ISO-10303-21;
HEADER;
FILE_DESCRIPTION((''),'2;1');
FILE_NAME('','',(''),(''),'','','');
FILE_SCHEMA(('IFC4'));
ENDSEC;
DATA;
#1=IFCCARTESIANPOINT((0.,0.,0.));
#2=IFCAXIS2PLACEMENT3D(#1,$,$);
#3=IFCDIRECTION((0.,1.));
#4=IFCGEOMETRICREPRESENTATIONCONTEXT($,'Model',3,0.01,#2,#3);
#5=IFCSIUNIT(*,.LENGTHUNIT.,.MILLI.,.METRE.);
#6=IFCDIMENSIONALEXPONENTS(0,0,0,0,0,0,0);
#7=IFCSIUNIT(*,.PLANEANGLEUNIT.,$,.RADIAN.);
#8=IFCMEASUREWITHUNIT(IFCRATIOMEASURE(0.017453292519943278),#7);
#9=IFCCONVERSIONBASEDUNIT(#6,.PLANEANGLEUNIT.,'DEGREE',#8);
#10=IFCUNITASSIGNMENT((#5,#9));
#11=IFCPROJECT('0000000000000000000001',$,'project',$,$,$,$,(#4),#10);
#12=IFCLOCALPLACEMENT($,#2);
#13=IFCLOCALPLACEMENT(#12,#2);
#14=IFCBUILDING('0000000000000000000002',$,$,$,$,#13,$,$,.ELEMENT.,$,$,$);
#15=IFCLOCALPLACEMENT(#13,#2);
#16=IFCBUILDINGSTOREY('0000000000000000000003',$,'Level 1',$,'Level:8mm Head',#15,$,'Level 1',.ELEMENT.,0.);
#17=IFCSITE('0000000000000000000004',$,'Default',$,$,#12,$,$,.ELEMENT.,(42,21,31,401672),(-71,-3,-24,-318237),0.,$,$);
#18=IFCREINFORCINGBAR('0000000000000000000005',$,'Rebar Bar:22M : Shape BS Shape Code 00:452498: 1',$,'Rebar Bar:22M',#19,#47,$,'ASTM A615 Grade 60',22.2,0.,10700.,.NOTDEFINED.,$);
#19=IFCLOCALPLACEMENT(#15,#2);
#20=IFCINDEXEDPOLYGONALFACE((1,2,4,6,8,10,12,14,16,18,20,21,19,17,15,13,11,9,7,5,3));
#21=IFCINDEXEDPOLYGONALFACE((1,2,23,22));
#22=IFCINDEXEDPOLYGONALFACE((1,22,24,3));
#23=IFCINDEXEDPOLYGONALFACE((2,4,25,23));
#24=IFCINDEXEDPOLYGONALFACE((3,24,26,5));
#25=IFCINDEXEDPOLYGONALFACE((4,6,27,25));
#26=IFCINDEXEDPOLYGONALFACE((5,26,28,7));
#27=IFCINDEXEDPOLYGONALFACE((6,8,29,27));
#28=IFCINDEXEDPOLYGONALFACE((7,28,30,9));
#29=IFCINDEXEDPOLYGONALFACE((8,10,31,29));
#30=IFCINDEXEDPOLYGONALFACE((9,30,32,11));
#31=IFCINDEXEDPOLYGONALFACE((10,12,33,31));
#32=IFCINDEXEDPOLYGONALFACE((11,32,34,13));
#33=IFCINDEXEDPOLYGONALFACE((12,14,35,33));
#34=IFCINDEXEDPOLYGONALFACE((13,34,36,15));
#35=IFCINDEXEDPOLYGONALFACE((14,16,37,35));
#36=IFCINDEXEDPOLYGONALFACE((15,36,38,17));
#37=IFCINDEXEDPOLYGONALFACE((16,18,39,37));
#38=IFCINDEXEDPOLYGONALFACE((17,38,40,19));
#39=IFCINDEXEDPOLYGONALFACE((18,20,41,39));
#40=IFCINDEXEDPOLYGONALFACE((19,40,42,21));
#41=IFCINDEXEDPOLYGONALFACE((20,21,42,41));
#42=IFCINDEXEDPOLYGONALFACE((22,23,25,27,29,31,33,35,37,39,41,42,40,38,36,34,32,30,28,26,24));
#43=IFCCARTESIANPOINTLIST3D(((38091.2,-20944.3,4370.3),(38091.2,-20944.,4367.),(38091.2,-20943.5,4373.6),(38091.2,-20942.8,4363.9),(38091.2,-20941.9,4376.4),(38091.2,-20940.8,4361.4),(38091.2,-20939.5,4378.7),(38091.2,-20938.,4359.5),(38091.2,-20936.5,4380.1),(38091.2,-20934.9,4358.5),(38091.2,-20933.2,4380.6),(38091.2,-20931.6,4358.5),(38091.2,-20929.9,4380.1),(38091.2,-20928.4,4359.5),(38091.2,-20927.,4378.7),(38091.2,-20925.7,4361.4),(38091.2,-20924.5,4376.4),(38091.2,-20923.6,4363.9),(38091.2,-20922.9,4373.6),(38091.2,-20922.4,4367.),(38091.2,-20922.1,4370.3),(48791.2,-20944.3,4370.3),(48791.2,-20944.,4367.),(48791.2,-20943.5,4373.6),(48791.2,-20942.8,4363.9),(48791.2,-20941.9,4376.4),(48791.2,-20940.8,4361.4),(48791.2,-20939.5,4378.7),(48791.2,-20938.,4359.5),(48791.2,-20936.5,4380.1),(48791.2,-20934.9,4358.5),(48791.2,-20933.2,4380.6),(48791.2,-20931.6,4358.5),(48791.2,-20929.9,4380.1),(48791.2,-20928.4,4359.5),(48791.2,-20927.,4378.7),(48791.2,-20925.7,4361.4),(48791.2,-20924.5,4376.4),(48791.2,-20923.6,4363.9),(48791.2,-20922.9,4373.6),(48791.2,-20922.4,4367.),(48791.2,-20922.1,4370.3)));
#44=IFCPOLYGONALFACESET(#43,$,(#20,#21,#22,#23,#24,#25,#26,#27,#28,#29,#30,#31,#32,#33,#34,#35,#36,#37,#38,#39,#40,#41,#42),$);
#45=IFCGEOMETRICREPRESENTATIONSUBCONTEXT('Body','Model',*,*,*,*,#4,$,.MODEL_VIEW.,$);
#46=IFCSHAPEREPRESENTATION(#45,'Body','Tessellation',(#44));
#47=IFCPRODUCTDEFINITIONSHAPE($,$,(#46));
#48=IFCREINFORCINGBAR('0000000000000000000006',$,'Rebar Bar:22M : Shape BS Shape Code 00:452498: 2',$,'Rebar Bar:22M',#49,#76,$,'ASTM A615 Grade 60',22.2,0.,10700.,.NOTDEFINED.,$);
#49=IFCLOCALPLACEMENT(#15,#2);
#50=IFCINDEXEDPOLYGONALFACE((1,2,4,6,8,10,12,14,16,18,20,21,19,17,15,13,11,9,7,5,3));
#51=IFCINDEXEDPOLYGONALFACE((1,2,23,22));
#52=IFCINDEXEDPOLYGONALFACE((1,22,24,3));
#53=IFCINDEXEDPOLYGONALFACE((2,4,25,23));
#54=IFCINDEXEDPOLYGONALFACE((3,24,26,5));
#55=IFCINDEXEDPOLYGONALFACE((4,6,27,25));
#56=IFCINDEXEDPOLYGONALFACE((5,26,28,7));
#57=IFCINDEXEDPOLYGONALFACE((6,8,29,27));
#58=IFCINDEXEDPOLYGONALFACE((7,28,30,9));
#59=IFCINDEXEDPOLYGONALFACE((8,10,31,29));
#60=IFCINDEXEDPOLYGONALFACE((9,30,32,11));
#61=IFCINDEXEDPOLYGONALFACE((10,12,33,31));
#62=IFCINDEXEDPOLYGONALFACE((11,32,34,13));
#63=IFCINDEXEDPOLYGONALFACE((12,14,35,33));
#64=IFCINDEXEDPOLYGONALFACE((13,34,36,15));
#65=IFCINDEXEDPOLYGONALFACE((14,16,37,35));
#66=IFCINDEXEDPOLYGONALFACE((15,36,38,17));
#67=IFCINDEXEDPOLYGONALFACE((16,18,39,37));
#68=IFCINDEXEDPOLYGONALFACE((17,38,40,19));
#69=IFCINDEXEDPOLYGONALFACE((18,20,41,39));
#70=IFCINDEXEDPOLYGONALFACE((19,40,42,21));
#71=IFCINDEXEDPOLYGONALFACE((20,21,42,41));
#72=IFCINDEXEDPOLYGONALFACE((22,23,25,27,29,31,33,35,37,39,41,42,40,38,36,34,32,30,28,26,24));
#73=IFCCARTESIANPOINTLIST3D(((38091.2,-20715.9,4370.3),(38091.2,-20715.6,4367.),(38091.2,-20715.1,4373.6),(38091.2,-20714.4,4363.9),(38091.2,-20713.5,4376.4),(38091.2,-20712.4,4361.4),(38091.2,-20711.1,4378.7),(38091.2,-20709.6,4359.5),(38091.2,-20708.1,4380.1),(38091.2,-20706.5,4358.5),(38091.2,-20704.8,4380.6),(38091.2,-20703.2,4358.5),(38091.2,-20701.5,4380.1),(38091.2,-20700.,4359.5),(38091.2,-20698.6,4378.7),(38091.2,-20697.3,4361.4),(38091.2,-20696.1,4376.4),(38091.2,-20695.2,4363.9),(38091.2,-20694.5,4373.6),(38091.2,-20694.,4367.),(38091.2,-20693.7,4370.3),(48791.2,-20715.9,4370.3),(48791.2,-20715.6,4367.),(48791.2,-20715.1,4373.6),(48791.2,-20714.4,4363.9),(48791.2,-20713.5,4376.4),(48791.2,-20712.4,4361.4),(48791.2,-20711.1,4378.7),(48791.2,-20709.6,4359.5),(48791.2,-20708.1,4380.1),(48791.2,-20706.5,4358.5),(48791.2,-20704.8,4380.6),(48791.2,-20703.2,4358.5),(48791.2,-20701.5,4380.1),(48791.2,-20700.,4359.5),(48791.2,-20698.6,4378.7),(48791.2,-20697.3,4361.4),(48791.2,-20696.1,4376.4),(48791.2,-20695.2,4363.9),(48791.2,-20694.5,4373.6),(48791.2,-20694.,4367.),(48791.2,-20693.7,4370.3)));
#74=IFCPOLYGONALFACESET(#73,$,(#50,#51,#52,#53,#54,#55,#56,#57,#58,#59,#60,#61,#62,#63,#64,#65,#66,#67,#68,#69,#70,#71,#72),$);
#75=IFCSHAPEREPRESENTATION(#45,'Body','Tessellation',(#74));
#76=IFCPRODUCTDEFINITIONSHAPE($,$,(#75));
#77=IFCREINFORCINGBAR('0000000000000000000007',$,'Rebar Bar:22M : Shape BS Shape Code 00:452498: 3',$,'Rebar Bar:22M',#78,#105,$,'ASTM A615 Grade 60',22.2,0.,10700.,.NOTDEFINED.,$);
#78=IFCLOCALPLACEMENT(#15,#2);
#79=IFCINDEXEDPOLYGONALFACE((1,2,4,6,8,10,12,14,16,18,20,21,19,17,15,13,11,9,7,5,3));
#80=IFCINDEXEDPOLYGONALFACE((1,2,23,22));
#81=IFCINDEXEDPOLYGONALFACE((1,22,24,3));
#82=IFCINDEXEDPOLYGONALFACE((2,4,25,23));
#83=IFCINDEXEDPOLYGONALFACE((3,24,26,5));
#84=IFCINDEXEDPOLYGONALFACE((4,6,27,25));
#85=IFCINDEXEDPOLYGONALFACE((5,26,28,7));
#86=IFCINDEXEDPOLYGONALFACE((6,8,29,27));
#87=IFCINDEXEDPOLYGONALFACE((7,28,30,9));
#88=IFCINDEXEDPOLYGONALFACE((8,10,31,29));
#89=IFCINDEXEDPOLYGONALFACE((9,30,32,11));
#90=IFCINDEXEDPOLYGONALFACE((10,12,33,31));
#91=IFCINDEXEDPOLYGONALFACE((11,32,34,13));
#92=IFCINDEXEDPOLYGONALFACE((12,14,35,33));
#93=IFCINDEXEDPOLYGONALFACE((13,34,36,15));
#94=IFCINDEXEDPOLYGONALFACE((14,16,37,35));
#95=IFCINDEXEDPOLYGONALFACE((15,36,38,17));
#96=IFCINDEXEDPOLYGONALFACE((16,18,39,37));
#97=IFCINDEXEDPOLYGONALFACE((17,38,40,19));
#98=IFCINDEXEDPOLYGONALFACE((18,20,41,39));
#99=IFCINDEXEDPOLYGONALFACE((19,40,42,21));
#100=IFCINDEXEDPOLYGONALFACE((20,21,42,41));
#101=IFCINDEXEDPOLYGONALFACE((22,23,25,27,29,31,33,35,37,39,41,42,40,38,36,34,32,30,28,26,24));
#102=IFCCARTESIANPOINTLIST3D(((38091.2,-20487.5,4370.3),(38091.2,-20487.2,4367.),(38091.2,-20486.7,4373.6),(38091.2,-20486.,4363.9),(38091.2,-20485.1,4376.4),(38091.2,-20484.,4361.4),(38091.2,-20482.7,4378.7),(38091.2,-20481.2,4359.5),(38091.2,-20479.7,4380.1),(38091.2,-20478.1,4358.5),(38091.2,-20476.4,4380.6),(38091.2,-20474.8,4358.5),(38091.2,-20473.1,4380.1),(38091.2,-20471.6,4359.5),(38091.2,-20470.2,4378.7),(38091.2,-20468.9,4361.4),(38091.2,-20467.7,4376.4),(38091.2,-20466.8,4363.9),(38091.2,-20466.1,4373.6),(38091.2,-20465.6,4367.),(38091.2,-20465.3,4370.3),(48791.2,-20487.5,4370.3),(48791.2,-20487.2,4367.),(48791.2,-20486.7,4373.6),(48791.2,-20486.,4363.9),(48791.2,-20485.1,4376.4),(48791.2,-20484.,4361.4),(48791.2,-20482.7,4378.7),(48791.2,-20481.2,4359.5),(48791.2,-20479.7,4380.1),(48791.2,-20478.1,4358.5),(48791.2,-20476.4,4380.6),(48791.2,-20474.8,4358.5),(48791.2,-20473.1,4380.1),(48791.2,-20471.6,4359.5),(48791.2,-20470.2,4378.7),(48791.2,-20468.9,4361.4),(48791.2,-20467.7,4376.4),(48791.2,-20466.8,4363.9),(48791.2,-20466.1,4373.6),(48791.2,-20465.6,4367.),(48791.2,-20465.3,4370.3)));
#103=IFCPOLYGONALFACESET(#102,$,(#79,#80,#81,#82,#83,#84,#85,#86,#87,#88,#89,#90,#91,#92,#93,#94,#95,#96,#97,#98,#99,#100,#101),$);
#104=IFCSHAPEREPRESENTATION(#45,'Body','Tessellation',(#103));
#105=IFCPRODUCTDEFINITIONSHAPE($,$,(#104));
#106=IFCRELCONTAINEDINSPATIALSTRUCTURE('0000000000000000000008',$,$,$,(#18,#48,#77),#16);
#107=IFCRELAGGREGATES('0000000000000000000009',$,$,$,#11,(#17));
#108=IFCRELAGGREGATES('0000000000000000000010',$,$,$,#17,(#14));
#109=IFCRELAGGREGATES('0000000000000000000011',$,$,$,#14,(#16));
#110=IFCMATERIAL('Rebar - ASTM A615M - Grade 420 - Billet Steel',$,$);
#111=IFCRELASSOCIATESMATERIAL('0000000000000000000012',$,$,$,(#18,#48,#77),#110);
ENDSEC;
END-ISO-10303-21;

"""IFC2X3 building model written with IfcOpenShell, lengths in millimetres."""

from ifc_helpers import new_model, entity, si_unit, converted_unit, direction, origin, place, context, subcontext, project, spatial, material, element, save


model = new_model("IFC2X3")

# Units and contexts
model_context = context("Model", 3, precision=0.01, world=origin(), true_north=direction((0.0, 1.0)))
body_context = subcontext(model_context, "Body", "Model", "MODEL_VIEW")
ifc_project = project(units=[si_unit("LENGTHUNIT", "METRE", prefix="MILLI"), converted_unit("PLANEANGLEUNIT", "DEGREE", entity("IfcRatioMeasure", 0.017453292519943278), si_unit("PLANEANGLEUNIT", "RADIAN"), dimensions=[0, 0, 0, 0, 0, 0, 0])], contexts=[model_context])

# Site, building, storey
site_placement = place(None, origin())
site = spatial("IfcSite", under=ifc_project, at=site_placement, Name="Default", CompositionType="ELEMENT", RefLatitude=(42, 21, 31, 401672), RefLongitude=(-71, -3, -24, -318237), RefElevation=0.0)
building_placement = place(site_placement, origin())
building = spatial("IfcBuilding", under=site, at=building_placement, CompositionType="ELEMENT")
storey_placement = place(building_placement, origin())
storey = spatial("IfcBuildingStorey", under=building, at=storey_placement, Name="Level 1", ObjectType="Level:8mm Head", LongName="Level 1", CompositionType="ELEMENT", Elevation=0.0)

# Reinforcing bars
ifc_material = material(Name="Rebar - ASTM A615M - Grade 420 - Billet Steel")
reinforcing_bar_1_placement = place(storey_placement, origin())
element("IfcReinforcingBar", 1, at=reinforcing_bar_1_placement, inside=storey, material=ifc_material, Name="Rebar Bar:22M : Shape BS Shape Code 00:452498: 1", SteelGrade="ASTM A615 Grade 60", ObjectType="Rebar Bar:22M", BarLength=10700.0, BarRole="NOTDEFINED", CrossSectionArea=0.0, NominalDiameter=22.2, context=body_context, shape_type="AdvancedSweptSolid", body=[
    entity("IfcSweptDiskSolid", entity("IfcCompositeCurve", [entity("IfcCompositeCurveSegment", "CONTINUOUS", True, entity("IfcPolyline", [entity("IfcCartesianPoint", [38091.2, -20933.2, 4369.5]), entity("IfcCartesianPoint", [48791.2, -20933.2, 4369.5])]))], False), 11.1, None, 0.0, 1.0),
])
reinforcing_bar_2_placement = place(storey_placement, origin())
element("IfcReinforcingBar", 2, at=reinforcing_bar_2_placement, inside=storey, material=ifc_material, Name="Rebar Bar:22M : Shape BS Shape Code 00:452498: 2", SteelGrade="ASTM A615 Grade 60", ObjectType="Rebar Bar:22M", BarLength=10700.0, BarRole="NOTDEFINED", CrossSectionArea=0.0, NominalDiameter=22.2, context=body_context, shape_type="AdvancedSweptSolid", body=[
    entity("IfcSweptDiskSolid", entity("IfcCompositeCurve", [entity("IfcCompositeCurveSegment", "CONTINUOUS", True, entity("IfcPolyline", [entity("IfcCartesianPoint", [38091.2, -20704.8, 4369.5]), entity("IfcCartesianPoint", [48791.2, -20704.8, 4369.5])]))], False), 11.1, None, 0.0, 1.0),
])
reinforcing_bar_3_placement = place(storey_placement, origin())
element("IfcReinforcingBar", 3, at=reinforcing_bar_3_placement, inside=storey, material=ifc_material, Name="Rebar Bar:22M : Shape BS Shape Code 00:452498: 3", SteelGrade="ASTM A615 Grade 60", ObjectType="Rebar Bar:22M", BarLength=10700.0, BarRole="NOTDEFINED", CrossSectionArea=0.0, NominalDiameter=22.2, context=body_context, shape_type="AdvancedSweptSolid", body=[
    entity("IfcSweptDiskSolid", entity("IfcCompositeCurve", [entity("IfcCompositeCurveSegment", "CONTINUOUS", True, entity("IfcPolyline", [entity("IfcCartesianPoint", [38091.2, -20476.4, 4369.5]), entity("IfcCartesianPoint", [48791.2, -20476.4, 4369.5])]))], False), 11.1, None, 0.0, 1.0),
])

save(model, "model.ifc")
